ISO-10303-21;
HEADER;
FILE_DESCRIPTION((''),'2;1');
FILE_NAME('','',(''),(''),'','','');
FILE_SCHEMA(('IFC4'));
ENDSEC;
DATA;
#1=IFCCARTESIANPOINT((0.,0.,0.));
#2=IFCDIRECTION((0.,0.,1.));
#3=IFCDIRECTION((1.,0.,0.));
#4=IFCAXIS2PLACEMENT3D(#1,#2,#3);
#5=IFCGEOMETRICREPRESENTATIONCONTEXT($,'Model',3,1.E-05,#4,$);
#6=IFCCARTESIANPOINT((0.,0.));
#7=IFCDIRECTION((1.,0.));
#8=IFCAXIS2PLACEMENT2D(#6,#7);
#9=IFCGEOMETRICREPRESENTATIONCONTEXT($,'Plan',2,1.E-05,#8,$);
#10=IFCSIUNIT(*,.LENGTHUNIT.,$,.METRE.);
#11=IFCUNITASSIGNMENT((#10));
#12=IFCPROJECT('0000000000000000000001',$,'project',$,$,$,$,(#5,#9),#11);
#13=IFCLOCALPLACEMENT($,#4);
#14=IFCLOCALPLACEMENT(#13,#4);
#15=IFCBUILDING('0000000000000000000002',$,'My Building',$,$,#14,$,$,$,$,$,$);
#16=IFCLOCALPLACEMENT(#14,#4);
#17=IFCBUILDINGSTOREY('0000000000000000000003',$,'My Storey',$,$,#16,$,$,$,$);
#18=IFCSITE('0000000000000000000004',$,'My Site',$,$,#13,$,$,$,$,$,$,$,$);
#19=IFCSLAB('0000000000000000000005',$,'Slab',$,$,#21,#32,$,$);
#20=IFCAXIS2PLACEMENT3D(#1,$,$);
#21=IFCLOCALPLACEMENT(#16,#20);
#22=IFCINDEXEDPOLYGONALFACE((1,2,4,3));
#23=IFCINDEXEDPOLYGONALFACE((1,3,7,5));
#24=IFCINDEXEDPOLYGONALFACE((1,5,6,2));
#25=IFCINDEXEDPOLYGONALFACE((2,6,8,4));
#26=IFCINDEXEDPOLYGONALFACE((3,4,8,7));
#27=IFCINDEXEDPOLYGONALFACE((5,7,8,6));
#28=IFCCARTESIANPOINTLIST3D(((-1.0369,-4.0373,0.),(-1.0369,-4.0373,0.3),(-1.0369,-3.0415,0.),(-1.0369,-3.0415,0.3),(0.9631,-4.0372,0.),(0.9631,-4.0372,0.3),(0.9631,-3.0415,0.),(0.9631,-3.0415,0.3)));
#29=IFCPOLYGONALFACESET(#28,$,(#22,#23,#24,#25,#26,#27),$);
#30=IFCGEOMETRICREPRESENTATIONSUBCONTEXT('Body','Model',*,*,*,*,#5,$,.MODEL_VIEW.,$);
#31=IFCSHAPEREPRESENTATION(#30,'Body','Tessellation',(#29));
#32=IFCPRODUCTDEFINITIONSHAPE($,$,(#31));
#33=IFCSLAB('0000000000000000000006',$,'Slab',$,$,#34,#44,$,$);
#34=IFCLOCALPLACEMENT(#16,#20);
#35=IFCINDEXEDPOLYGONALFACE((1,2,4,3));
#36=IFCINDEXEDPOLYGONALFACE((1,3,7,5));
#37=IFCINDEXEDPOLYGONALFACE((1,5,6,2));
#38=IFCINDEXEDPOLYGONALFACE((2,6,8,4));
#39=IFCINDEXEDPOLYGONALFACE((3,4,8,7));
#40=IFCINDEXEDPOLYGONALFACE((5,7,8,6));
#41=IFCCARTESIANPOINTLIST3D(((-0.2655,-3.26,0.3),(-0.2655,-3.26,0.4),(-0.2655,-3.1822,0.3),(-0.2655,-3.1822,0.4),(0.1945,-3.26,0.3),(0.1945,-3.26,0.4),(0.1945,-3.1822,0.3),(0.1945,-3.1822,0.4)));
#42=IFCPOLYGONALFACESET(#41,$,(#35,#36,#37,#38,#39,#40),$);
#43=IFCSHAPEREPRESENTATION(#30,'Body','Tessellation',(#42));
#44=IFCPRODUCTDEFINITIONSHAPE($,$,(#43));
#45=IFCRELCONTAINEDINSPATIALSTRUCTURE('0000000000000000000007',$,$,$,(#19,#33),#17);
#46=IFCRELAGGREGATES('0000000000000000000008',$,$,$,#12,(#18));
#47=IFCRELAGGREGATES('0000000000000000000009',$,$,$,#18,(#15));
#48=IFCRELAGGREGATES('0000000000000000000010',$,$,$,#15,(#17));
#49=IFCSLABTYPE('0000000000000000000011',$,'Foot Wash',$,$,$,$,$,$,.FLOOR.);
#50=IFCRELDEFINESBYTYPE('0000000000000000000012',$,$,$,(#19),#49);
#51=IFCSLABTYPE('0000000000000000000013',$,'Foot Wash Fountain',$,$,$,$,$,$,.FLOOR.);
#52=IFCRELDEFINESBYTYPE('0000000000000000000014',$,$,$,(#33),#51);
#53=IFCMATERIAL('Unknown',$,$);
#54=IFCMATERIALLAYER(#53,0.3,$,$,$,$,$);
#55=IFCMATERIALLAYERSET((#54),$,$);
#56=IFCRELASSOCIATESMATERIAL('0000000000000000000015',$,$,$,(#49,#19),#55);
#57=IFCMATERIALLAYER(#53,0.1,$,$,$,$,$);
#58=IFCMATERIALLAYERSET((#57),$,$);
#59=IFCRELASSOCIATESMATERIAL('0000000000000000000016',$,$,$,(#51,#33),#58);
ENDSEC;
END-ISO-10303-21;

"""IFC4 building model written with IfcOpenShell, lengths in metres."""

from ifc_helpers import new_model, si_unit, frame, origin_with_axes, origin_2d_with_axis, place, context, subcontext, project, spatial, indexed_curve, outline, extrude, material, layer, layer_set, layer_usage, type_object, element, save


model = new_model("IFC4")

# Units and contexts
model_context = context("Model", 3, precision=1e-05, world=origin_with_axes())
plan_context = context("Plan", 2, precision=1e-05, world=origin_2d_with_axis())
body_context = subcontext(model_context, "Body", "Model", "MODEL_VIEW")
ifc_project = project(units=[si_unit("LENGTHUNIT", "METRE")], contexts=[model_context, plan_context])

# Site, building, storey
site_placement = place(None, origin_with_axes())
site = spatial("IfcSite", under=ifc_project, at=site_placement, Name="My Site")
building_placement = place(site_placement, origin_with_axes())
building = spatial("IfcBuilding", under=site, at=building_placement, Name="My Building")
storey_placement = place(building_placement, origin_with_axes())
storey = spatial("IfcBuildingStorey", under=building, at=storey_placement, Name="My Storey")

# Slabs
ifc_material = material(Name="Unknown")
ifc_layer_1 = layer(ifc_material, 0.3)
ifc_layer_set_1 = layer_set([ifc_layer_1])
ifc_layer_usage_1 = layer_usage(ifc_layer_set_1, "AXIS3", "POSITIVE", -0.3)
slab_type_1 = type_object("IfcSlabType", Name="Foot Wash", PredefinedType="FLOOR", material=ifc_layer_set_1)
slab_1_placement = place(storey_placement, frame((-1.0369, -4.0373, 0.3), z_axis=(0.0, 0.0, 1.0), x_axis=(1.0, 0.0, 0.0)))
element("IfcSlab", 1, at=slab_1_placement, inside=storey, type_object=slab_type_1, material=ifc_layer_usage_1, Name="Slab", context=body_context, shape_type="SweptSolid", body=[
    extrude(outline(indexed_curve([(0.0, 0.0), (0.0, 0.9958), (2.0, 0.9958), (2.0, 0.0001), (0.0, 0.0)])), frame((0.0, 0.0, -0.3), z_axis=(0.0, 0.0, 1.0), x_axis=(1.0, 0.0, 0.0)), (0.0, 0.0, 1.0), 0.3),
])
ifc_layer_2 = layer(ifc_material, 0.1)
ifc_layer_set_2 = layer_set([ifc_layer_2])
ifc_layer_usage_2 = layer_usage(ifc_layer_set_2, "AXIS3", "POSITIVE", -0.3)
slab_type_2 = type_object("IfcSlabType", Name="Foot Wash Fountain", PredefinedType="FLOOR", material=ifc_layer_set_2)
slab_2_placement = place(storey_placement, frame((-0.2655, -3.1822, 0.6), z_axis=(0.0, 0.0, 1.0), x_axis=(1.0, 0.0, 0.0)))
element("IfcSlab", 2, at=slab_2_placement, inside=storey, type_object=slab_type_2, material=ifc_layer_usage_2, Name="Slab", context=body_context, shape_type="SweptSolid", body=[
    extrude(outline(indexed_curve([(0.0, 0.0), (0.0, -0.0778), (0.46, -0.0778), (0.46, 0.0), (0.0, 0.0)])), frame((0.0, 0.0, -0.3), z_axis=(0.0, 0.0, 1.0), x_axis=(1.0, 0.0, 0.0)), (0.0, 0.0, 1.0), 0.1),
])

save(model, "model.ifc")
